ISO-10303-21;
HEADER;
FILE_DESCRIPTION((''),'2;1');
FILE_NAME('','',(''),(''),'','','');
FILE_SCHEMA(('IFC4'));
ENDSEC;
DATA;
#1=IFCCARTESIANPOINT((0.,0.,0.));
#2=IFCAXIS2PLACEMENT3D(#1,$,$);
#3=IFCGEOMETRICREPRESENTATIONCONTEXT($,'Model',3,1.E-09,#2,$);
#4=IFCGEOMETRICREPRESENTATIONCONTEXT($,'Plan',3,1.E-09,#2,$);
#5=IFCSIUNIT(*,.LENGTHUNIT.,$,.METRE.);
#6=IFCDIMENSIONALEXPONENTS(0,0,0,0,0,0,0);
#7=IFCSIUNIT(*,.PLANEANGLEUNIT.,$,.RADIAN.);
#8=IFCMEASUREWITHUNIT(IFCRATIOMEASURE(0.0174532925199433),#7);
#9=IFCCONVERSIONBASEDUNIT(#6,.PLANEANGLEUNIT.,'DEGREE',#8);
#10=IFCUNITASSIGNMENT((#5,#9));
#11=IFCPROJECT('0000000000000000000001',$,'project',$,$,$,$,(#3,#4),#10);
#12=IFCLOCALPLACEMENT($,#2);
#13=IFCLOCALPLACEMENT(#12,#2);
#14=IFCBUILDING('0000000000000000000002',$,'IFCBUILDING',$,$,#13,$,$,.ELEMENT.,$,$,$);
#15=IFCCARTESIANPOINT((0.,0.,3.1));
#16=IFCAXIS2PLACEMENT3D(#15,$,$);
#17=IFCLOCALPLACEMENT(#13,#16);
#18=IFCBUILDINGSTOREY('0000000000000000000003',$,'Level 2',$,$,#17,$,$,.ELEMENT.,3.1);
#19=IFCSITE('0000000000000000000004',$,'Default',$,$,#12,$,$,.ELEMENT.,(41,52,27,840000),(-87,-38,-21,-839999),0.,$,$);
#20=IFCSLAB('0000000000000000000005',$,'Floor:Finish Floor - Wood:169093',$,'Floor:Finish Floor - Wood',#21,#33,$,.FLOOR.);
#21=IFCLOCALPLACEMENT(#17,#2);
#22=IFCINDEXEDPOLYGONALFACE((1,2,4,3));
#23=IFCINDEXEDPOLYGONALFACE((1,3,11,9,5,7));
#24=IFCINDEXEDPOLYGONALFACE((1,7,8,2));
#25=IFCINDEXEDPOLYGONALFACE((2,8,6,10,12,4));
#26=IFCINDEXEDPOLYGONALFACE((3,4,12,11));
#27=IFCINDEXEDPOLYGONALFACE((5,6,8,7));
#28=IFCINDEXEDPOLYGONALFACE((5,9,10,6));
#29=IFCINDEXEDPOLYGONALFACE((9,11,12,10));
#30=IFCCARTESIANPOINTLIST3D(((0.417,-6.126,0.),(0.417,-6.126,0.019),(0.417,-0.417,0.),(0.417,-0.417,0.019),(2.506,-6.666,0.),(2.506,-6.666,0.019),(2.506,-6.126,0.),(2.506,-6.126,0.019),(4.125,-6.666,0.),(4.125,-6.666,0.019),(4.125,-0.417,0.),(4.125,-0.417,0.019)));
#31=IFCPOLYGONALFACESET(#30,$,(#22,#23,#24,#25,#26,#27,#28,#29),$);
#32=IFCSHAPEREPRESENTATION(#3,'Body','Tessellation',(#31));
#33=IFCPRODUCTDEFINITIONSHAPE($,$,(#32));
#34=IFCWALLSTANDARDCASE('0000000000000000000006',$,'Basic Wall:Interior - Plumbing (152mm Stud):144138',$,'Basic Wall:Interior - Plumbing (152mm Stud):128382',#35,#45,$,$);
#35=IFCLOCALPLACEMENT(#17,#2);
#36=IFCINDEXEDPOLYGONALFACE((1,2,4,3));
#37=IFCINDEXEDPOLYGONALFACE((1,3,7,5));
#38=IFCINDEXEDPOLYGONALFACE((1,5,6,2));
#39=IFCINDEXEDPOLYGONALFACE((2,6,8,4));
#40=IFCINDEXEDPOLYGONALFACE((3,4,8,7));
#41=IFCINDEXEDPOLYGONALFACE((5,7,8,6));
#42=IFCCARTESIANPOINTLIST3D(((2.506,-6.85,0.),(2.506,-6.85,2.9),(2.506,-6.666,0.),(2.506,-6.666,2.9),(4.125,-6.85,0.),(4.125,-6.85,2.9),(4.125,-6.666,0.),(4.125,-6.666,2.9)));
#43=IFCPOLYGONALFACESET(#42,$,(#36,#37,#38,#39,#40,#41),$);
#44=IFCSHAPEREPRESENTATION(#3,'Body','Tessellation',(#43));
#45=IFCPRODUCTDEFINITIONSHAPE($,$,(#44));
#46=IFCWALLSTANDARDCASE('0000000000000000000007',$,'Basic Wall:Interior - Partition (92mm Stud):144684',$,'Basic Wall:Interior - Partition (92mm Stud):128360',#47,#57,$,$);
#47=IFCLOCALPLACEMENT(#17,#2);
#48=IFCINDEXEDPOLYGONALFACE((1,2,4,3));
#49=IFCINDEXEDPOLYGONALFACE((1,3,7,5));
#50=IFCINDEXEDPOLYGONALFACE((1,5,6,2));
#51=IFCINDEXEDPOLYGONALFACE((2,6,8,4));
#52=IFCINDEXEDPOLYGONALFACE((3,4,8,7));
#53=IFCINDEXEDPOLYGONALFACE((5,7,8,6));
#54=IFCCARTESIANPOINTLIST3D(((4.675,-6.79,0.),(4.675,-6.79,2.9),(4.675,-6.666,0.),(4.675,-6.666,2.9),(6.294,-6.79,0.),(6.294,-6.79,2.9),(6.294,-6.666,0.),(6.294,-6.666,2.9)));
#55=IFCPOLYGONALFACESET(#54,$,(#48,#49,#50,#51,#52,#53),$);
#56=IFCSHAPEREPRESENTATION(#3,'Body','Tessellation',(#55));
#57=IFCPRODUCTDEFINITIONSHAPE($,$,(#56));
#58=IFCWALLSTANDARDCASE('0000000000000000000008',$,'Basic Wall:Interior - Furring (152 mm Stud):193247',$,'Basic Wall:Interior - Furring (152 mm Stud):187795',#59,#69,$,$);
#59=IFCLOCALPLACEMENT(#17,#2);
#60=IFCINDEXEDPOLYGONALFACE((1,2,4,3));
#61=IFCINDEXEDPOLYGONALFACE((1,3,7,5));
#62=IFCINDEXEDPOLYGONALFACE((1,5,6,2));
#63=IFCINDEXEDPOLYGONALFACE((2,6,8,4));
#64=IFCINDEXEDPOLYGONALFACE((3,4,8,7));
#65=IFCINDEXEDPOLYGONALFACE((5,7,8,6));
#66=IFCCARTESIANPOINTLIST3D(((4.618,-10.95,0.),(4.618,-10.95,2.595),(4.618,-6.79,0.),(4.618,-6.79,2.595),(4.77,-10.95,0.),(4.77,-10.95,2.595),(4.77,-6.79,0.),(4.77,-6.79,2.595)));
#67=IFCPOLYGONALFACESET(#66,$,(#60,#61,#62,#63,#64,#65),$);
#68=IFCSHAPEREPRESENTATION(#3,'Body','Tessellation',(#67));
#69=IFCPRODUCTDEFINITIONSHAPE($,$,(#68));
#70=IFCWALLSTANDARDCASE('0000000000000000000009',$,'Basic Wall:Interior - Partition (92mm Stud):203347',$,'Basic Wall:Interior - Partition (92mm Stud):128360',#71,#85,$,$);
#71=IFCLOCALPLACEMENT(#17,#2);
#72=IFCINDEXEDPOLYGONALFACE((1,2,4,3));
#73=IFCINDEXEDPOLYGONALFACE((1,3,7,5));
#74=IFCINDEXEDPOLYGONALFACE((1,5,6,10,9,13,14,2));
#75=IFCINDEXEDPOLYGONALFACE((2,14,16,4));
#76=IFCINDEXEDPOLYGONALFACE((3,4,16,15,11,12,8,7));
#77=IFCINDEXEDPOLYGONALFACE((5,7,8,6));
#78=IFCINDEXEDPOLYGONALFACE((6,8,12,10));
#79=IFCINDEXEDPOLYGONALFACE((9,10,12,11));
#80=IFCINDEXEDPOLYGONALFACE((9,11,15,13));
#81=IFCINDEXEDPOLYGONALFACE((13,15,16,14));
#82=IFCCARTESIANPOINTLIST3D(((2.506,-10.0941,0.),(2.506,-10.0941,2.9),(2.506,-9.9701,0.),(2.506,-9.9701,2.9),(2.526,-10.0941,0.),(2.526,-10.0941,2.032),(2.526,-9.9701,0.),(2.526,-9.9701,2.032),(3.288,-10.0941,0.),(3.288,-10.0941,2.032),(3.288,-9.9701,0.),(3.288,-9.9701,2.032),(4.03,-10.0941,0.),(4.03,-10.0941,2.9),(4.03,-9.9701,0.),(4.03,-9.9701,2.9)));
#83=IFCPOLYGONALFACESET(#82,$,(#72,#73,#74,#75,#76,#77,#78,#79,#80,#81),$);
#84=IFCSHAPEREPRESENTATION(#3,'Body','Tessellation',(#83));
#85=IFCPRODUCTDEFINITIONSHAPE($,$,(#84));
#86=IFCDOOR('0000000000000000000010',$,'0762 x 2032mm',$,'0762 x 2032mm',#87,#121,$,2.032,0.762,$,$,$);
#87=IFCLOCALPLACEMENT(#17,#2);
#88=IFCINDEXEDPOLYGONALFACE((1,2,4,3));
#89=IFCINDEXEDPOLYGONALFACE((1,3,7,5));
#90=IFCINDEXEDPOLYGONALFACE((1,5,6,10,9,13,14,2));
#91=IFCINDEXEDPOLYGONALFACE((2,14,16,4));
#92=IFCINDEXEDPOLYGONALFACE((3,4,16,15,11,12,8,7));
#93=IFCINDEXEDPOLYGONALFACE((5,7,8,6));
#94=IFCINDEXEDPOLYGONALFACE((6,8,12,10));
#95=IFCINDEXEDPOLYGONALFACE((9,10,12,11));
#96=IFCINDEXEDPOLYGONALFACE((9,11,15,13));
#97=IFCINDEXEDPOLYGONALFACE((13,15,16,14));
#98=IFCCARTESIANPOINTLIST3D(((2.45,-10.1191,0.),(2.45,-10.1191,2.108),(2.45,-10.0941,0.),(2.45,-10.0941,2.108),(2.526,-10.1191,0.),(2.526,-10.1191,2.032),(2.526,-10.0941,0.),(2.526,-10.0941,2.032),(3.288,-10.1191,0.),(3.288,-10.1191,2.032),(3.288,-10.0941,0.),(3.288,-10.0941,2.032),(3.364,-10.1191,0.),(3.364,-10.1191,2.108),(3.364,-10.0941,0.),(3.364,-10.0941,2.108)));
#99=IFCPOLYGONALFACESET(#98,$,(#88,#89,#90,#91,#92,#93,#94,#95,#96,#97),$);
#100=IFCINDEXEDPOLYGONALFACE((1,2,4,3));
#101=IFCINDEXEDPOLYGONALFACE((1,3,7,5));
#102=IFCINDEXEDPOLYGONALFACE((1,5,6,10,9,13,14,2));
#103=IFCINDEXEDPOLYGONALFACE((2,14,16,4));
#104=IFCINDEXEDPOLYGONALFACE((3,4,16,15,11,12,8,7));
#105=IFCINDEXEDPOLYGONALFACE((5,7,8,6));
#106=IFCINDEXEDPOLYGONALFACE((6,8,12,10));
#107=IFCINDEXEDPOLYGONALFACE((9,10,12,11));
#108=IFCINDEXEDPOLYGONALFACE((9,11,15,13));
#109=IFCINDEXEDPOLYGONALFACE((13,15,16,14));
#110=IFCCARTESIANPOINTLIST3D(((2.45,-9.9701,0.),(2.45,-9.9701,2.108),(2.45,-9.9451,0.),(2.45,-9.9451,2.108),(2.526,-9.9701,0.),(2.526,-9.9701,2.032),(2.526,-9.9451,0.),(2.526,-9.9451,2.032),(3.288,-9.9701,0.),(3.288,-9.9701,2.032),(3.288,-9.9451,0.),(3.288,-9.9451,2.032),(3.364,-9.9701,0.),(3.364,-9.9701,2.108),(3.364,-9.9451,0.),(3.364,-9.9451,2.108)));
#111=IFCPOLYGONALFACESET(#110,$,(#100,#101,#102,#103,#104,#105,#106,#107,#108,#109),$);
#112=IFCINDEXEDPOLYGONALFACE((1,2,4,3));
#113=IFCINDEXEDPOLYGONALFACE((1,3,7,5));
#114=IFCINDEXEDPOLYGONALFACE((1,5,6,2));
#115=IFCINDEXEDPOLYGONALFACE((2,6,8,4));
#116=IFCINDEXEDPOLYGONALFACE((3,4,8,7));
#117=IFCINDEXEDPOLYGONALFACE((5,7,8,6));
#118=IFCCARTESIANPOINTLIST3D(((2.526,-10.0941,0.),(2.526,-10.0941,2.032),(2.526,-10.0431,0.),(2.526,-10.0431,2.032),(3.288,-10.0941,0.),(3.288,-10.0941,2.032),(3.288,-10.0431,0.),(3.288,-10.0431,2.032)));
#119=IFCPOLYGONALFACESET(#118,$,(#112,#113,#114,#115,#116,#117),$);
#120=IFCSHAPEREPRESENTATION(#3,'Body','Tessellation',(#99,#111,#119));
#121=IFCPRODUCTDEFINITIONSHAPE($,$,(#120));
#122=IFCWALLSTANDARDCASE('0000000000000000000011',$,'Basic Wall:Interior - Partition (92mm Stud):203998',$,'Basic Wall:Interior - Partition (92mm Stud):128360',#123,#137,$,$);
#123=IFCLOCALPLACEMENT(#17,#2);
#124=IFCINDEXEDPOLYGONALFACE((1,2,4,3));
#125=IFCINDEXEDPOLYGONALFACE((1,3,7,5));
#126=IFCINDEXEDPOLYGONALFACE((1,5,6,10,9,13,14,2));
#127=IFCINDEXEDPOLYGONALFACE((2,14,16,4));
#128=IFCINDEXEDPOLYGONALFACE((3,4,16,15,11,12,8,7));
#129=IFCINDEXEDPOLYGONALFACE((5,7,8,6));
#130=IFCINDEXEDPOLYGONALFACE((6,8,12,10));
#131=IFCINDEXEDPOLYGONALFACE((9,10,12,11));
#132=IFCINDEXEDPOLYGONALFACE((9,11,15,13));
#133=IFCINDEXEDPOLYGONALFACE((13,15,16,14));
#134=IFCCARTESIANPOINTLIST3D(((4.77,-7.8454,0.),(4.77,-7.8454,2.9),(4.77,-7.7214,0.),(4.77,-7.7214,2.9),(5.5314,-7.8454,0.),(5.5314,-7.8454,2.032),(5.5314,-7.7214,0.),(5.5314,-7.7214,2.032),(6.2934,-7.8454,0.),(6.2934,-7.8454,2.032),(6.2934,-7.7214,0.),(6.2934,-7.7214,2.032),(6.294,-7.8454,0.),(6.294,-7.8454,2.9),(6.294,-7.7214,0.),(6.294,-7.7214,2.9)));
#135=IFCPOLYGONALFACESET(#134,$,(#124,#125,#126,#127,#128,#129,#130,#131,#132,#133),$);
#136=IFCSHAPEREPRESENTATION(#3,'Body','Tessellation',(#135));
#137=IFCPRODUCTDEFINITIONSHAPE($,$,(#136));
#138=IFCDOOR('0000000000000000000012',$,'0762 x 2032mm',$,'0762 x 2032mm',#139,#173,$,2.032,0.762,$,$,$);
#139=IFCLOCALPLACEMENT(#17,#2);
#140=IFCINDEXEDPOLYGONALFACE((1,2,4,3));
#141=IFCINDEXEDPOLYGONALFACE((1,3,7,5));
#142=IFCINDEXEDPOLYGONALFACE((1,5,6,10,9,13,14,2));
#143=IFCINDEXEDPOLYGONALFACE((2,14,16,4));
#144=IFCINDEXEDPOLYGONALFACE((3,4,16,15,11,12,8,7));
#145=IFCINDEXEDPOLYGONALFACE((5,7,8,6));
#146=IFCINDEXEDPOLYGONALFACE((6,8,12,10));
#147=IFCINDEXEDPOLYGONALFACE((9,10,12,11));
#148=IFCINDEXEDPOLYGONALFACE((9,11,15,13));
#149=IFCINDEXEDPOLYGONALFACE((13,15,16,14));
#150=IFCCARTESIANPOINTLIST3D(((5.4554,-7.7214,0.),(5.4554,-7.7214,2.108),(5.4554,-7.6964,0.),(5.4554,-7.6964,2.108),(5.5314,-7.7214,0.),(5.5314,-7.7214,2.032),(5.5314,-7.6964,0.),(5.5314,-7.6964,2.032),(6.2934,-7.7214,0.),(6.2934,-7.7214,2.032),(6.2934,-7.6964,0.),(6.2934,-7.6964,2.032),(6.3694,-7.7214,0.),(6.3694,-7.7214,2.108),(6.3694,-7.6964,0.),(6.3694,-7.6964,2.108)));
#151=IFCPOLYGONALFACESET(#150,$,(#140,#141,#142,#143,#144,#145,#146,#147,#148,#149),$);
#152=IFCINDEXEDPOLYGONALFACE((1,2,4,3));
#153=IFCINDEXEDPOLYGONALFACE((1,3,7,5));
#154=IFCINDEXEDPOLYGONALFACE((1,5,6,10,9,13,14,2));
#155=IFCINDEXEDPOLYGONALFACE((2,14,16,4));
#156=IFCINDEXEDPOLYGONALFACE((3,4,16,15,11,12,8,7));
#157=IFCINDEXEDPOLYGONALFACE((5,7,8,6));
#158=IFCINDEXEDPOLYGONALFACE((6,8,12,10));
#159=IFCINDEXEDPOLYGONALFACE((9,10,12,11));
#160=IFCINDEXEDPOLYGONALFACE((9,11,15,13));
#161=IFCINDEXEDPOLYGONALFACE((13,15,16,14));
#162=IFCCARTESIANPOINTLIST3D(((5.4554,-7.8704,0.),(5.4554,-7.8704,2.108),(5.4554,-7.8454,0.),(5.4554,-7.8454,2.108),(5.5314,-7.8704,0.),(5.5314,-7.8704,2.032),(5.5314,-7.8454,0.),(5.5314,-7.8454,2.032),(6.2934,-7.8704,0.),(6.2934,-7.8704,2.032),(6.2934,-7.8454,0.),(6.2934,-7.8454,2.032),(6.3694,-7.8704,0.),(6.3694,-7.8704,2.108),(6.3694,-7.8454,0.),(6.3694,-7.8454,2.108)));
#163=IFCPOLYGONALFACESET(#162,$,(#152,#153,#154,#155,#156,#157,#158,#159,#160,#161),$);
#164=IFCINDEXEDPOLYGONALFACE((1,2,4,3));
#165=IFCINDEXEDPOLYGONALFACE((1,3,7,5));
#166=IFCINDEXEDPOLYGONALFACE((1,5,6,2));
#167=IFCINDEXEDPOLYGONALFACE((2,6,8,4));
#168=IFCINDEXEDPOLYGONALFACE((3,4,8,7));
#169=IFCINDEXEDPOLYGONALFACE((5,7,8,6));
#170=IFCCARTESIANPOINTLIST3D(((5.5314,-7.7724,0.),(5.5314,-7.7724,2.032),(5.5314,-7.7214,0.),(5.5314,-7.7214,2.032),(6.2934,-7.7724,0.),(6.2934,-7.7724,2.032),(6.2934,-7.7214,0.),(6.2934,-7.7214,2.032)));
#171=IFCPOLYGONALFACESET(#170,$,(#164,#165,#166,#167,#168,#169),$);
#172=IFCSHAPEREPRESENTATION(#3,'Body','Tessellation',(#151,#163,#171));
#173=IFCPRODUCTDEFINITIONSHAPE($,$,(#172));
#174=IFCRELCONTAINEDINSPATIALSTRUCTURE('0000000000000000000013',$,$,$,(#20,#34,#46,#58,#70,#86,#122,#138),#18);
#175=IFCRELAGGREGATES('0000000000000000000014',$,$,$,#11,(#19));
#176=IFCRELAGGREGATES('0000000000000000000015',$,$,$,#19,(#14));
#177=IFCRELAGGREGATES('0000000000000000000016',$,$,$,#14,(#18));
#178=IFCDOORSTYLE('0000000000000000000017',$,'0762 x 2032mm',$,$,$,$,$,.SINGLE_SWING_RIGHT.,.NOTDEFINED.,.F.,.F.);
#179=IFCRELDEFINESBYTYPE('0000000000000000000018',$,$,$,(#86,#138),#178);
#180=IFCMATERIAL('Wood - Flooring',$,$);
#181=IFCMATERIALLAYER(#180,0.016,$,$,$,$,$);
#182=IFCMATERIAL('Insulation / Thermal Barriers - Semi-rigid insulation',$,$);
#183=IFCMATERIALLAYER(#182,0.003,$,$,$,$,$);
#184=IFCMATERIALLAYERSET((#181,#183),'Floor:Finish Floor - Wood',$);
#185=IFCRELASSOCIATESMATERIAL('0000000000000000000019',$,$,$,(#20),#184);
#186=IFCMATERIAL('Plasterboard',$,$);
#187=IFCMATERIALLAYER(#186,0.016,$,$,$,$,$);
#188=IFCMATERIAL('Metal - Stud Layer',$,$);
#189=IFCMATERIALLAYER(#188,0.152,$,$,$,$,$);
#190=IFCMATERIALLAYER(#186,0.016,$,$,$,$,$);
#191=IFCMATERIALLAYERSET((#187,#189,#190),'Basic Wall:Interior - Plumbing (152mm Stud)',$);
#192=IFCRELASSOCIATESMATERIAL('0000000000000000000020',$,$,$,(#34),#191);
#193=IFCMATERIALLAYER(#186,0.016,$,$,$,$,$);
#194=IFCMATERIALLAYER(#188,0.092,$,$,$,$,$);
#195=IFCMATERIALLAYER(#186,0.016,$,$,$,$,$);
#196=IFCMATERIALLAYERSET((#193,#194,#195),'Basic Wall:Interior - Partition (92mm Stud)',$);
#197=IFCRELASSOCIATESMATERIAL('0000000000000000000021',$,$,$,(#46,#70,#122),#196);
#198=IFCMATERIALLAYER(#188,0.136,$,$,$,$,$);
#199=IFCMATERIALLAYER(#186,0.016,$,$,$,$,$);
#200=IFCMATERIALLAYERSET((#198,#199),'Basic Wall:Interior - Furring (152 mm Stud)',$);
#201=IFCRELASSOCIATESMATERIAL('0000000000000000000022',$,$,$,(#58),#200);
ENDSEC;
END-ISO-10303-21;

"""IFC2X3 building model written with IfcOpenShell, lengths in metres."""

from ifc_helpers import new_model, entity, si_unit, converted_unit, frame, frame_2d, origin, origin_2d_with_axis, place, context, project, spatial, polyline, rectangle, outline, extrude, source, transform, mapped, material, layer, layer_set, layer_usage, type_object, type_shapes, element, fill, save


model = new_model("IFC2X3")

# Units and contexts
model_context = context("Model", 3, precision=1e-09, world=origin())
plan_context = context("Plan", 3, precision=1e-09, world=origin())
ifc_project = project(units=[si_unit("LENGTHUNIT", "METRE"), converted_unit("PLANEANGLEUNIT", "DEGREE", entity("IfcRatioMeasure", 0.0174532925199433), si_unit("PLANEANGLEUNIT", "RADIAN"), dimensions=[0, 0, 0, 0, 0, 0, 0])], contexts=[model_context, plan_context])

# Site, building, storey
site_placement = place(None, origin())
site = spatial("IfcSite", under=ifc_project, at=site_placement, Name="Default", CompositionType="ELEMENT", RefLatitude=(41, 52, 27, 840000), RefLongitude=(-87, -38, -21, -839999), RefElevation=0.0)
building_placement = place(site_placement, origin())
building = spatial("IfcBuilding", under=site, at=building_placement, Name="IFCBUILDING", CompositionType="ELEMENT")
storey_placement = place(building_placement, frame((0.0, 0.0, 3.1)))
storey = spatial("IfcBuildingStorey", under=building, at=storey_placement, Name="Level 2", CompositionType="ELEMENT", Elevation=3.1)

# Slab
ifc_material_1 = material(Name="Wood - Flooring")
ifc_layer_1 = layer(ifc_material_1, 0.016)
ifc_material_2 = material(Name="Insulation / Thermal Barriers - Semi-rigid insulation")
ifc_layer_2 = layer(ifc_material_2, 0.003)
ifc_layer_set_1 = layer_set([ifc_layer_1, ifc_layer_2], Name="Floor:Finish Floor - Wood")
ifc_layer_usage_1 = layer_usage(ifc_layer_set_1, "AXIS3", "POSITIVE", 0.0)
slab_placement = place(storey_placement, frame((0.417, -6.666, 0.0)))
element("IfcSlab", 1, at=slab_placement, inside=storey, material=ifc_layer_usage_1, Name="Floor:Finish Floor - Wood:169093", ObjectType="Floor:Finish Floor - Wood", PredefinedType="FLOOR", context=model_context, shape_type="SweptSolid", body=[
    extrude(outline(polyline([(1.854, 3.1245), (-1.854, 3.1245), (-1.854, -3.1245), (-0.235, -3.1245), (-0.235, -2.5845), (1.854, -2.5845), (1.854, 3.1245)])), frame((1.854, 3.1245, 0.019), z_axis=(0.0, 0.0, -1.0), x_axis=(-1.0, 0.0, 0.0)), (0.0, 0.0, 1.0), 0.019),
])

# Walls
ifc_material_3 = material(Name="Plasterboard")
ifc_layer_3 = layer(ifc_material_3, 0.016)
ifc_material_4 = material(Name="Metal - Stud Layer")
ifc_layer_4 = layer(ifc_material_4, 0.152)
ifc_layer_5 = layer(ifc_material_3, 0.016)
ifc_layer_set_2 = layer_set([ifc_layer_3, ifc_layer_4, ifc_layer_5], Name="Basic Wall:Interior - Plumbing (152mm Stud)")
ifc_layer_usage_2 = layer_usage(ifc_layer_set_2, "AXIS2", "NEGATIVE", 0.092)
wall_1_placement = place(storey_placement, frame((2.506, -6.758, 0.0)))
element("IfcWallStandardCase", 2, at=wall_1_placement, inside=storey, material=ifc_layer_usage_2, Name="Basic Wall:Interior - Plumbing (152mm Stud):144138", ObjectType="Basic Wall:Interior - Plumbing (152mm Stud):128382", context=model_context, shape_type="SweptSolid", body=[
    extrude(rectangle(XDim=1.619, YDim=0.184, at=frame_2d((0.8095, 0.0), x_axis=(-1.0, 0.0))), origin(), (0.0, 0.0, 1.0), 2.9),
])
ifc_layer_6 = layer(ifc_material_3, 0.016)
ifc_layer_7 = layer(ifc_material_4, 0.092)
ifc_layer_8 = layer(ifc_material_3, 0.016)
ifc_layer_set_3 = layer_set([ifc_layer_6, ifc_layer_7, ifc_layer_8], Name="Basic Wall:Interior - Partition (92mm Stud)")
ifc_layer_usage_3 = layer_usage(ifc_layer_set_3, "AXIS2", "NEGATIVE", 0.062)
wall_2_placement = place(storey_placement, frame((4.675, -6.728, 0.0)))
element("IfcWallStandardCase", 3, at=wall_2_placement, inside=storey, material=ifc_layer_usage_3, Name="Basic Wall:Interior - Partition (92mm Stud):144684", ObjectType="Basic Wall:Interior - Partition (92mm Stud):128360", context=model_context, shape_type="SweptSolid", body=[
    extrude(rectangle(XDim=1.619, YDim=0.124, at=frame_2d((0.8095, 0.0), x_axis=(-1.0, 0.0))), origin(), (0.0, 0.0, 1.0), 2.9),
])
ifc_layer_9 = layer(ifc_material_4, 0.136)
ifc_layer_10 = layer(ifc_material_3, 0.016)
ifc_layer_set_4 = layer_set([ifc_layer_9, ifc_layer_10], Name="Basic Wall:Interior - Furring (152 mm Stud)")
ifc_layer_usage_4 = layer_usage(ifc_layer_set_4, "AXIS2", "POSITIVE", -0.076)
wall_3_placement = place(storey_placement, frame((4.694, -6.79, 0.0), z_axis=(0.0, 0.0, 1.0), x_axis=(0.0, -1.0, 0.0)))
element("IfcWallStandardCase", 4, at=wall_3_placement, inside=storey, material=ifc_layer_usage_4, Name="Basic Wall:Interior - Furring (152 mm Stud):193247", ObjectType="Basic Wall:Interior - Furring (152 mm Stud):187795", context=model_context, shape_type="SweptSolid", body=[
    extrude(rectangle(XDim=4.16, YDim=0.152, at=frame_2d((2.08, 0.0), x_axis=(-1.0, 0.0))), origin(), (0.0, 0.0, 1.0), 2.595),
])

# Walls, openings, doors
ifc_layer_usage_5 = layer_usage(ifc_layer_set_3, "AXIS2", "NEGATIVE", 0.062)
wall_4_placement = place(storey_placement, frame((4.03, -10.0321, 0.0), z_axis=(0.0, 0.0, 1.0), x_axis=(-1.0, 0.0, 0.0)))
wall_4 = element("IfcWallStandardCase", 5, at=wall_4_placement, inside=storey, material=ifc_layer_usage_5, Name="Basic Wall:Interior - Partition (92mm Stud):203347", ObjectType="Basic Wall:Interior - Partition (92mm Stud):128360", context=model_context, shape_type="SweptSolid", body=[
    extrude(rectangle(XDim=1.524, YDim=0.124, at=frame_2d((0.762, 0.0), x_axis=(-1.0, 0.0))), origin(), (0.0, 0.0, 1.0), 2.9),
])
opening_1_placement = place(wall_4_placement, frame((0.742, -0.062, 0.0)))
opening_1 = element("IfcOpeningElement", 6, at=opening_1_placement, cuts=wall_4, ObjectType="Opening", context=model_context, shape_type="SweptSolid", body=[
    extrude(rectangle(XDim=0.762, YDim=2.032, at=frame_2d((1.016, 0.381), x_axis=(0.0, 1.0))), frame((0.0, 0.0, 0.0), z_axis=(0.0, 1.0, 0.0), x_axis=(0.0, 0.0, 1.0)), (0.0, 0.0, 1.0), 0.124),
])
door_style = type_object("IfcDoorStyle", Name="0762 x 2032mm", ConstructionType="NOTDEFINED", OperationType="SINGLE_SWING_RIGHT", ParameterTakesPrecedence=False, Sizeable=False)
shared_shape = source(origin(), model_context, "Body", "SweptSolid", [
    extrude(outline(polyline([(-0.457, -1.073), (0.457, -1.073), (0.457, 1.035), (0.381, 1.035), (0.381, -0.997), (-0.381, -0.997), (-0.381, 1.035), (-0.457, 1.035), (-0.457, -1.073)])), frame((0.381, 0.124, 1.035), z_axis=(0.0, 1.0, 0.0), x_axis=(1.0, 0.0, 0.0)), (0.0, 0.0, 1.0), 0.025),
    extrude(outline(polyline([(-1.073, -0.457), (1.035, -0.457), (1.035, -0.381), (-0.997, -0.381), (-0.997, 0.381), (1.035, 0.381), (1.035, 0.457), (-1.073, 0.457), (-1.073, -0.457)])), frame((0.381, -0.025, 1.035), z_axis=(0.0, 1.0, 0.0), x_axis=(0.0, 0.0, -1.0)), (0.0, 0.0, 1.0), 0.025),
    extrude(rectangle(XDim=0.051, YDim=0.762, at=origin_2d_with_axis()), frame((0.381, 0.0985, 0.0), z_axis=(0.0, 0.0, 1.0), x_axis=(0.0, 1.0, 0.0)), (0.0, 0.0, 1.0), 2.032),
])
type_shapes(door_style, [shared_shape])
door_1_placement = place(opening_1_placement, origin())
door_1 = element("IfcDoor", 7, at=door_1_placement, inside=storey, type_object=door_style, Name="0762 x 2032mm", ObjectType="0762 x 2032mm", OverallHeight=2.032, OverallWidth=0.762, context=model_context, shape_type="MappedRepresentation", body=[
    mapped(shared_shape, transform((0.0, 0.0, 0.0), scale=1.0)),
])
fill(opening_1, door_1)
ifc_layer_usage_6 = layer_usage(ifc_layer_set_3, "AXIS2", "POSITIVE", -0.062)
wall_5_placement = place(storey_placement, frame((4.77, -7.7834, 0.0)))
wall_5 = element("IfcWallStandardCase", 8, at=wall_5_placement, inside=storey, material=ifc_layer_usage_6, Name="Basic Wall:Interior - Partition (92mm Stud):203998", ObjectType="Basic Wall:Interior - Partition (92mm Stud):128360", context=model_context, shape_type="SweptSolid", body=[
    extrude(rectangle(XDim=1.524, YDim=0.124, at=frame_2d((0.762, 0.0), x_axis=(-1.0, 0.0))), origin(), (0.0, 0.0, 1.0), 2.9),
])
opening_2_placement = place(wall_5_placement, frame((0.7614, -0.062, 0.0)))
opening_2 = element("IfcOpeningElement", 9, at=opening_2_placement, cuts=wall_5, ObjectType="Opening", context=model_context, shape_type="SweptSolid", body=[
    extrude(rectangle(XDim=0.762, YDim=2.032, at=frame_2d((1.016, 0.381), x_axis=(0.0, 1.0))), frame((0.0, 0.0, 0.0), z_axis=(0.0, 1.0, 0.0), x_axis=(0.0, 0.0, 1.0)), (0.0, 0.0, 1.0), 0.124),
])
door_2_placement = place(opening_2_placement, origin())
door_2 = element("IfcDoor", 10, at=door_2_placement, inside=storey, type_object=door_style, Name="0762 x 2032mm", ObjectType="0762 x 2032mm", OverallHeight=2.032, OverallWidth=0.762, context=model_context, shape_type="MappedRepresentation", body=[
    mapped(shared_shape, transform((0.0, 0.0, 0.0), scale=1.0)),
])
fill(opening_2, door_2)

save(model, "model.ifc")
